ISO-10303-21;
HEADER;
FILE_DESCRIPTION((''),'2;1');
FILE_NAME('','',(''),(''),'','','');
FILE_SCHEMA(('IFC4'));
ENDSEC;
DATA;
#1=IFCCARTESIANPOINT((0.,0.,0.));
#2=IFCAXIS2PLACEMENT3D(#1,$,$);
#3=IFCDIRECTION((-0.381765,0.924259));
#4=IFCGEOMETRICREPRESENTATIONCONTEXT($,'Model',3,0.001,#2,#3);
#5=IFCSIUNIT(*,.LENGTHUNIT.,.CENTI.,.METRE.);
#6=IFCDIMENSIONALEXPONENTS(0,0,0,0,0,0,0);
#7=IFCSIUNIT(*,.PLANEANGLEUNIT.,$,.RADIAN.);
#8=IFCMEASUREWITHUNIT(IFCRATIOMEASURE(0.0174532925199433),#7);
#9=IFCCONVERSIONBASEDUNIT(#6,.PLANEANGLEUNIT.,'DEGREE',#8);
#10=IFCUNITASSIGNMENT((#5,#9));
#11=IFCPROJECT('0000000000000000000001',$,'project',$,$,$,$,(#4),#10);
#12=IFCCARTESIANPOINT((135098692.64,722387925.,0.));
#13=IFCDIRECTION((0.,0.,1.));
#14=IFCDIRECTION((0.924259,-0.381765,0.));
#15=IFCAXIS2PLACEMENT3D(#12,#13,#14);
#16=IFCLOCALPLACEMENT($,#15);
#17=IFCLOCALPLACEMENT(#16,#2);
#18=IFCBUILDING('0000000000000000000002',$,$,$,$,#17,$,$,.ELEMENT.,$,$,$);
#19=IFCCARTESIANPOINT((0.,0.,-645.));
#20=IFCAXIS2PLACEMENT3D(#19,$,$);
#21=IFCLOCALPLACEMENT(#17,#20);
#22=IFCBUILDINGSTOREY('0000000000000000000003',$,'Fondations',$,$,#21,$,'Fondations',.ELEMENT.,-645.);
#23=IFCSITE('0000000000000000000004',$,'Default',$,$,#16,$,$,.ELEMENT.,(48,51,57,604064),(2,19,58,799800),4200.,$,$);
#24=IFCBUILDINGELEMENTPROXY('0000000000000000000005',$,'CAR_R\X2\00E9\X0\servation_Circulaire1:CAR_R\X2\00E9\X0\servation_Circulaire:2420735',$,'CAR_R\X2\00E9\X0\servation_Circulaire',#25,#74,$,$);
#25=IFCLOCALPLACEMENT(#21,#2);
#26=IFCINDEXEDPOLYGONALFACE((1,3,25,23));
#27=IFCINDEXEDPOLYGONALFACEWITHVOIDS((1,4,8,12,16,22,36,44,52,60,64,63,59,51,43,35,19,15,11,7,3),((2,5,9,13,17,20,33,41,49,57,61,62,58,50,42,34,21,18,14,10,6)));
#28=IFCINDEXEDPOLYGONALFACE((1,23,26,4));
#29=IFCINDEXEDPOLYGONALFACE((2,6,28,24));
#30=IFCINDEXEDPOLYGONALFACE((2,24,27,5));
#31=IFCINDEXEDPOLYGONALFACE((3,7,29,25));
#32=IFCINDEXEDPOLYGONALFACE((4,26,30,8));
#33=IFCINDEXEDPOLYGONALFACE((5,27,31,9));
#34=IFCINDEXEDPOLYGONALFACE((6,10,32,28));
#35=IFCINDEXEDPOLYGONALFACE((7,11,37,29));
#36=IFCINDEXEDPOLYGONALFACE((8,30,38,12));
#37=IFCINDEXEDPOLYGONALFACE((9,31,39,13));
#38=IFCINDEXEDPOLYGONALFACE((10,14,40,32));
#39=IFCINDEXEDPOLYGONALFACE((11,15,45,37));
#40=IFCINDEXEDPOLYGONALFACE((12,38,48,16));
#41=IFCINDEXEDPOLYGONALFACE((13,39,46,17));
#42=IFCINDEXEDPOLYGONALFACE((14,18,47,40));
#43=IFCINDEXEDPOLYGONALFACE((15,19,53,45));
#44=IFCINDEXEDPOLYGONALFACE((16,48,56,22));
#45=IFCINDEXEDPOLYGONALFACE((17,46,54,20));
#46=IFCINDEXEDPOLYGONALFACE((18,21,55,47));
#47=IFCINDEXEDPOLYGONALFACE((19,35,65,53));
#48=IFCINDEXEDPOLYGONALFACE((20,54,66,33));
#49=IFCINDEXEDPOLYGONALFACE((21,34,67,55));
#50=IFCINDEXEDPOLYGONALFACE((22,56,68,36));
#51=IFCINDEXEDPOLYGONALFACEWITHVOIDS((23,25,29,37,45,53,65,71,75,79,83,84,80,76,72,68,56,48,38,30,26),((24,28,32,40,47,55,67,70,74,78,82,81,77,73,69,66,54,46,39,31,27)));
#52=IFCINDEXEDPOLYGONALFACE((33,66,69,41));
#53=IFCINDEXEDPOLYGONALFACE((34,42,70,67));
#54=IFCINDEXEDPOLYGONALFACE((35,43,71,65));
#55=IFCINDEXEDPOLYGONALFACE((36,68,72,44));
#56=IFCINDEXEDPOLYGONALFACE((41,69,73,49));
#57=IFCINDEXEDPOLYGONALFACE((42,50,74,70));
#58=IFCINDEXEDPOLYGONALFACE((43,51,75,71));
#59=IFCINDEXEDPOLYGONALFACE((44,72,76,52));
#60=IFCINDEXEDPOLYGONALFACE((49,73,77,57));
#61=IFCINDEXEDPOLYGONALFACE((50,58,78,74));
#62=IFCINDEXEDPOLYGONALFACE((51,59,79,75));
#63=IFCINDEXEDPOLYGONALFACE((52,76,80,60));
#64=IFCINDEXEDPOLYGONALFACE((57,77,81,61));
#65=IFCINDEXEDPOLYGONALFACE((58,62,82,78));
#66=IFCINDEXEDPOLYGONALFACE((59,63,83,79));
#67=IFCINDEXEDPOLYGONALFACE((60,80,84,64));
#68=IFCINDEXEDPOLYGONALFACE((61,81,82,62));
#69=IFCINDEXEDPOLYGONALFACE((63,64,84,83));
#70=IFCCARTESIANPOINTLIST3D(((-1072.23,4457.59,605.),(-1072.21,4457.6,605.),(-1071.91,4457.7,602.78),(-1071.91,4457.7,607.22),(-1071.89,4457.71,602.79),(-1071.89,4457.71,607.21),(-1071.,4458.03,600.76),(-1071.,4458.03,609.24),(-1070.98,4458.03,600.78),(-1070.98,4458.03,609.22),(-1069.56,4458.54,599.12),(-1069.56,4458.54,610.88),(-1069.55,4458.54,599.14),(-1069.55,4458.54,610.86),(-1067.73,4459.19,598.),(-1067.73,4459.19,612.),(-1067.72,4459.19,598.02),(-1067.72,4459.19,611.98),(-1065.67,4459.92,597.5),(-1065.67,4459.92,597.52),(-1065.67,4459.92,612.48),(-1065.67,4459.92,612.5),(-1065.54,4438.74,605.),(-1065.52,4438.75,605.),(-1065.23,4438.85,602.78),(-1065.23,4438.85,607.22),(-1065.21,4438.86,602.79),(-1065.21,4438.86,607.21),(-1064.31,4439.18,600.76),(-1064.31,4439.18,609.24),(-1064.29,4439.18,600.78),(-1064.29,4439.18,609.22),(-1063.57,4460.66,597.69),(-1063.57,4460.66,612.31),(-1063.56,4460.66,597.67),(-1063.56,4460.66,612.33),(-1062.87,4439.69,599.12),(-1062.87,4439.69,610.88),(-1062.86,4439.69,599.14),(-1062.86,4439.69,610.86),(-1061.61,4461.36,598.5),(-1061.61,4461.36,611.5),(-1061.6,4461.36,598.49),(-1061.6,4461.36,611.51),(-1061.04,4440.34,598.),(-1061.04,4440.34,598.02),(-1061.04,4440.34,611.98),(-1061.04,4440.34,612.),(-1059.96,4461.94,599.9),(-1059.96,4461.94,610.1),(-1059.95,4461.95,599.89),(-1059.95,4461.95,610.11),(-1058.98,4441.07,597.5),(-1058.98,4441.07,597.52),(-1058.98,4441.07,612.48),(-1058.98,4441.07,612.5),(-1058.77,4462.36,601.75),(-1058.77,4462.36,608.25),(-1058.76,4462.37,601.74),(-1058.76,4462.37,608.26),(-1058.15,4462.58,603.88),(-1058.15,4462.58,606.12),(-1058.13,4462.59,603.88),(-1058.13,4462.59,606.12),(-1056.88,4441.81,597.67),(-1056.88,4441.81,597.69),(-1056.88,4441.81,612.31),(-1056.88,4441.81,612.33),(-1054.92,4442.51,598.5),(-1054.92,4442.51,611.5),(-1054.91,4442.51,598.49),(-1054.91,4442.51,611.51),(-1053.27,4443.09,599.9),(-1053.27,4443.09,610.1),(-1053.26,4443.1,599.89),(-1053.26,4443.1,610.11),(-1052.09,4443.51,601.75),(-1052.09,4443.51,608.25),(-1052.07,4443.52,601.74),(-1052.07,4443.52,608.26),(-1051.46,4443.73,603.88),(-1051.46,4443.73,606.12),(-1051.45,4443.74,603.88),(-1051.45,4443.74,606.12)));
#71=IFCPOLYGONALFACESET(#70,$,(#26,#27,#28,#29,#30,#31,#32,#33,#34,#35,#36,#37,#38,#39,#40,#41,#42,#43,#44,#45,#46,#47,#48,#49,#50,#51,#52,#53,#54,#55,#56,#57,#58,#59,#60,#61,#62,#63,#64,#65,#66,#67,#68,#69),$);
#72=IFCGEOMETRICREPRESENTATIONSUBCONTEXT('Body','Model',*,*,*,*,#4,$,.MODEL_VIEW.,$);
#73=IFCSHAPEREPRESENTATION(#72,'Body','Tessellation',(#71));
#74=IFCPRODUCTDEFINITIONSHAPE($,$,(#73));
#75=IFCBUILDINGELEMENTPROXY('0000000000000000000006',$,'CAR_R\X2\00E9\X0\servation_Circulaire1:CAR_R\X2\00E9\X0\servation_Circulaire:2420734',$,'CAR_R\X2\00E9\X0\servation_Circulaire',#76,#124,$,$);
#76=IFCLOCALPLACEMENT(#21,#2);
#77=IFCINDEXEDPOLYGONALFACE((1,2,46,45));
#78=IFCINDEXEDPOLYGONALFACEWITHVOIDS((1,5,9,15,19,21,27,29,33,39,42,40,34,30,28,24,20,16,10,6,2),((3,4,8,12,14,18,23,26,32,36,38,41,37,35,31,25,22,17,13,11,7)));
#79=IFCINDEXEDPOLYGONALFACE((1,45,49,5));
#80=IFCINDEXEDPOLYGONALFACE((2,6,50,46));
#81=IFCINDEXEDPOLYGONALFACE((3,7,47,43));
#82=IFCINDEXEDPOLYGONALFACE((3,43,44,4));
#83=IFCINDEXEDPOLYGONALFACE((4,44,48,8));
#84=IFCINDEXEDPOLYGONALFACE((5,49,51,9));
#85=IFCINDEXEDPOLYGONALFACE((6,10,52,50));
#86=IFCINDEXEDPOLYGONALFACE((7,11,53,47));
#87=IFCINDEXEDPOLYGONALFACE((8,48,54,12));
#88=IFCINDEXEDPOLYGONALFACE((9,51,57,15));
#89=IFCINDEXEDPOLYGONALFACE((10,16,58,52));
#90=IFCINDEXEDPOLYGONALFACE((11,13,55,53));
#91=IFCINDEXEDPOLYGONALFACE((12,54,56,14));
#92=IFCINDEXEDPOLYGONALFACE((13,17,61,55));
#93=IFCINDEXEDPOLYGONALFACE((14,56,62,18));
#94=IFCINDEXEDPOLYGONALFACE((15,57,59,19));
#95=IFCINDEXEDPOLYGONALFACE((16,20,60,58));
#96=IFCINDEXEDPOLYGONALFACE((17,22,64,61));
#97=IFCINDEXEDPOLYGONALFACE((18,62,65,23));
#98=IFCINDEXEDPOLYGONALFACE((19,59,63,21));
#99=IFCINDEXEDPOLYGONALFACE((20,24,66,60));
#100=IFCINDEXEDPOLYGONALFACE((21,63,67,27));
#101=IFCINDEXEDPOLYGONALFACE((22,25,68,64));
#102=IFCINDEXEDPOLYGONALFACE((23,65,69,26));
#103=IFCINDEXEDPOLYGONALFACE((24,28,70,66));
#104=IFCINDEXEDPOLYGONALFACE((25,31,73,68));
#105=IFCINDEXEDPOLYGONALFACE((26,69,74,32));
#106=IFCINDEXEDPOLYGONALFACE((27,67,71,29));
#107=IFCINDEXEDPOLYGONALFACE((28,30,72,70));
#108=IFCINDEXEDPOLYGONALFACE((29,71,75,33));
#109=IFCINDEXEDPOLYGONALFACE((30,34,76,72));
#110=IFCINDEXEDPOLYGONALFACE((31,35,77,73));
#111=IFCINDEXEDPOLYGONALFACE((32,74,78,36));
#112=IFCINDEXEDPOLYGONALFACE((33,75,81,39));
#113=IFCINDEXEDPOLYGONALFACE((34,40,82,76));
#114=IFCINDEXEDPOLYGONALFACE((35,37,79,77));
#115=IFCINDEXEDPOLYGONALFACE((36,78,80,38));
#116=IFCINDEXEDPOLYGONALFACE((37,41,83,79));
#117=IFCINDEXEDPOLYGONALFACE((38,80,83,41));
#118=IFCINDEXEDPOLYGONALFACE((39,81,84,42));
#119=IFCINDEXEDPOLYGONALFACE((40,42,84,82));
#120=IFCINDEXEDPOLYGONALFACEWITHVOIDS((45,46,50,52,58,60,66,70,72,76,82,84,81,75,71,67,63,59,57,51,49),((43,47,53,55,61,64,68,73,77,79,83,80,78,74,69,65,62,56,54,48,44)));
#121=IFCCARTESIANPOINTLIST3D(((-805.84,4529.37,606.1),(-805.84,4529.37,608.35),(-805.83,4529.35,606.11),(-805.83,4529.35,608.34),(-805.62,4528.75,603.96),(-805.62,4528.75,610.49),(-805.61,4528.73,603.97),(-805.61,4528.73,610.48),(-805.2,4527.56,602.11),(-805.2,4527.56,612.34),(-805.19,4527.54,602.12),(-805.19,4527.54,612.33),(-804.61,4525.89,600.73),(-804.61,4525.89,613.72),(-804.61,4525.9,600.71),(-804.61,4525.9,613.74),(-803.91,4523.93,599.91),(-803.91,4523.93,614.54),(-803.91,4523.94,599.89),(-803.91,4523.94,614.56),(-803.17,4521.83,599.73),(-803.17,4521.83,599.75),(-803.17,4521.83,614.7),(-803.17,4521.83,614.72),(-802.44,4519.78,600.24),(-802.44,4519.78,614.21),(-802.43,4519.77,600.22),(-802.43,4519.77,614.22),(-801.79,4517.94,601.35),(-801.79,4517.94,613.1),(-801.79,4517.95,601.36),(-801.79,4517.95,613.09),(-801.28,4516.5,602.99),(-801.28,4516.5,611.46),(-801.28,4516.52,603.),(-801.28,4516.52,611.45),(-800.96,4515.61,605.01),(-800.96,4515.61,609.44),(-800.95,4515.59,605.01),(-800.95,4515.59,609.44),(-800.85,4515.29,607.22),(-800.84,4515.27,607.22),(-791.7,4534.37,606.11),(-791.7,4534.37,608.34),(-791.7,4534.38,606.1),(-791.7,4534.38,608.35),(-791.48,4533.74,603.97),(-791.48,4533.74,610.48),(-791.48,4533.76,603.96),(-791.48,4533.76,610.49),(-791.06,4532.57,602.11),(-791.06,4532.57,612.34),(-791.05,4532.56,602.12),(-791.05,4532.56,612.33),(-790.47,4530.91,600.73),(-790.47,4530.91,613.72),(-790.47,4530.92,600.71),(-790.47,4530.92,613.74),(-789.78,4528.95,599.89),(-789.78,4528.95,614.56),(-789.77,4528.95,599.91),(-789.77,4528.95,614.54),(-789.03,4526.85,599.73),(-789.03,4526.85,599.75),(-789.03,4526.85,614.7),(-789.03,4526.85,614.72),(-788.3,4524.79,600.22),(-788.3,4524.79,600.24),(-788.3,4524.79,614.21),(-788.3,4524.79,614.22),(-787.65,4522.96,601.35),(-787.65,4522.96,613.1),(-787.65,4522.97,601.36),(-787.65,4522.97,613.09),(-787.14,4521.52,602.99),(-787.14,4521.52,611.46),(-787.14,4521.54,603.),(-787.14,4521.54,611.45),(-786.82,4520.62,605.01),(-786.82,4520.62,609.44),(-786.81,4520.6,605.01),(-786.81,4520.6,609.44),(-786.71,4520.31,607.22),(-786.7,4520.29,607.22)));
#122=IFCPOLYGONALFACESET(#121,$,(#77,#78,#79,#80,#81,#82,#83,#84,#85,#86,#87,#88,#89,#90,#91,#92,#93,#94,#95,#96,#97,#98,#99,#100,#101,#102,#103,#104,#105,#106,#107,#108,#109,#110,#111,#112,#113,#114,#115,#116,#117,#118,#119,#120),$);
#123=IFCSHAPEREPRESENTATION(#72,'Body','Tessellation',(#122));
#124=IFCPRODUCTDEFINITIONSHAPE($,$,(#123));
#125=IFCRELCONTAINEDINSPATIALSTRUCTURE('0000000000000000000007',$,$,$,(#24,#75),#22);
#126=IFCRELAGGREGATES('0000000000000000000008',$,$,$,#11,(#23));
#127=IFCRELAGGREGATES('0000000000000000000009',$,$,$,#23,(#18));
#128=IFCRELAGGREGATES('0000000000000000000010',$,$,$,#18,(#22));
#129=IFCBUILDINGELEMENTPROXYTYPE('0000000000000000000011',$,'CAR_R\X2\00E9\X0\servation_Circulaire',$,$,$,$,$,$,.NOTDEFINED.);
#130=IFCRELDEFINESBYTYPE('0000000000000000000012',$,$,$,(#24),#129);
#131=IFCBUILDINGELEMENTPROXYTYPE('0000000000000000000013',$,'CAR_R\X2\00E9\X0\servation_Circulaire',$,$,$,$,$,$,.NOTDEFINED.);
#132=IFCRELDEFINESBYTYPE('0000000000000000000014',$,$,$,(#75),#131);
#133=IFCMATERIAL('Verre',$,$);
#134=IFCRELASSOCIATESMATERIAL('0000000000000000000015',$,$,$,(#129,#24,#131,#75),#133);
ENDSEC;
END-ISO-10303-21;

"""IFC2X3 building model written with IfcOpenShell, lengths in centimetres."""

from ifc_helpers import new_model, entity, si_unit, converted_unit, direction, frame, frame_2d, origin, place, context, subcontext, project, spatial, hollow_circle, extrude, source, transform, mapped, material, type_object, type_shapes, element, save


model = new_model("IFC2X3")

# Units and contexts
model_context = context("Model", 3, precision=0.001, world=origin(), true_north=direction((-0.381765, 0.924259)))
body_context = subcontext(model_context, "Body", "Model", "MODEL_VIEW")
ifc_project = project(units=[si_unit("LENGTHUNIT", "METRE", prefix="CENTI"), converted_unit("PLANEANGLEUNIT", "DEGREE", entity("IfcRatioMeasure", 0.0174532925199433), si_unit("PLANEANGLEUNIT", "RADIAN"), dimensions=[0, 0, 0, 0, 0, 0, 0])], contexts=[model_context])

# Site, building, storey
site_placement = place(None, frame((135098692.64, 722387925.0, 0.0), z_axis=(0.0, 0.0, 1.0), x_axis=(0.924259, -0.381765, 0.0)))
site = spatial("IfcSite", under=ifc_project, at=site_placement, Name="Default", CompositionType="ELEMENT", RefLatitude=(48, 51, 57, 604064), RefLongitude=(2, 19, 58, 799800), RefElevation=4200.0)
building_placement = place(site_placement, origin())
building = spatial("IfcBuilding", under=site, at=building_placement, CompositionType="ELEMENT")
storey_placement = place(building_placement, frame((0.0, 0.0, -645.0)))
storey = spatial("IfcBuildingStorey", under=building, at=storey_placement, Name="Fondations", LongName="Fondations", CompositionType="ELEMENT", Elevation=-645.0)

# Building element proxies
ifc_material_1 = material(Name="Verre")
building_element_proxy_type_1 = type_object("IfcBuildingElementProxyType", Name="CAR_Réservation_Circulaire", PredefinedType="NOTDEFINED", material=ifc_material_1)
shared_shape_1 = source(origin(), body_context, "Body", "SweptSolid", [
    extrude(hollow_circle(Radius=7.52, WallThickness=0.02, at=frame_2d((0.0, 0.0), x_axis=(1.0, 0.0))), frame((0.0, 0.0, -20.0)), (0.0, 0.0, 1.0), 20.0),
])
type_shapes(building_element_proxy_type_1, [shared_shape_1])
proxy_1_placement = place(storey_placement, frame((-1065.14, 4460.1, 605.0), z_axis=(-0.334331, 0.942456, 0.0), x_axis=(-0.942456, -0.334331, 0.0)))
element("IfcBuildingElementProxy", 1, at=proxy_1_placement, inside=storey, type_object=building_element_proxy_type_1, material=ifc_material_1, Name="CAR_Réservation_Circulaire1:CAR_Réservation_Circulaire:2420735", ObjectType="CAR_Réservation_Circulaire", context=body_context, shape_type="MappedRepresentation", body=[
    mapped(shared_shape_1, transform((0.0, 0.0, 0.0), scale=1.0)),
])
building_element_proxy_type_2 = type_object("IfcBuildingElementProxyType", Name="CAR_Réservation_Circulaire", PredefinedType="NOTDEFINED", material=ifc_material_1)
shared_shape_2 = source(origin(), body_context, "Body", "SweptSolid", [
    extrude(hollow_circle(Radius=7.52, WallThickness=0.02, at=frame_2d((0.0, 0.0), x_axis=(1.0, 0.0))), frame((0.0, 0.0, -15.0)), (0.0, 0.0, 1.0), 15.0),
])
type_shapes(building_element_proxy_type_2, [shared_shape_2])
proxy_2_placement = place(storey_placement, frame((-803.35, 4522.36, 607.22), z_axis=(-0.942456, -0.334331, 0.0), x_axis=(0.334331, -0.942456, 0.0)))
element("IfcBuildingElementProxy", 2, at=proxy_2_placement, inside=storey, type_object=building_element_proxy_type_2, material=ifc_material_1, Name="CAR_Réservation_Circulaire1:CAR_Réservation_Circulaire:2420734", ObjectType="CAR_Réservation_Circulaire", context=body_context, shape_type="MappedRepresentation", body=[
    mapped(shared_shape_2, transform((0.0, 0.0, 0.0), scale=1.0)),
])

save(model, "model.ifc")
